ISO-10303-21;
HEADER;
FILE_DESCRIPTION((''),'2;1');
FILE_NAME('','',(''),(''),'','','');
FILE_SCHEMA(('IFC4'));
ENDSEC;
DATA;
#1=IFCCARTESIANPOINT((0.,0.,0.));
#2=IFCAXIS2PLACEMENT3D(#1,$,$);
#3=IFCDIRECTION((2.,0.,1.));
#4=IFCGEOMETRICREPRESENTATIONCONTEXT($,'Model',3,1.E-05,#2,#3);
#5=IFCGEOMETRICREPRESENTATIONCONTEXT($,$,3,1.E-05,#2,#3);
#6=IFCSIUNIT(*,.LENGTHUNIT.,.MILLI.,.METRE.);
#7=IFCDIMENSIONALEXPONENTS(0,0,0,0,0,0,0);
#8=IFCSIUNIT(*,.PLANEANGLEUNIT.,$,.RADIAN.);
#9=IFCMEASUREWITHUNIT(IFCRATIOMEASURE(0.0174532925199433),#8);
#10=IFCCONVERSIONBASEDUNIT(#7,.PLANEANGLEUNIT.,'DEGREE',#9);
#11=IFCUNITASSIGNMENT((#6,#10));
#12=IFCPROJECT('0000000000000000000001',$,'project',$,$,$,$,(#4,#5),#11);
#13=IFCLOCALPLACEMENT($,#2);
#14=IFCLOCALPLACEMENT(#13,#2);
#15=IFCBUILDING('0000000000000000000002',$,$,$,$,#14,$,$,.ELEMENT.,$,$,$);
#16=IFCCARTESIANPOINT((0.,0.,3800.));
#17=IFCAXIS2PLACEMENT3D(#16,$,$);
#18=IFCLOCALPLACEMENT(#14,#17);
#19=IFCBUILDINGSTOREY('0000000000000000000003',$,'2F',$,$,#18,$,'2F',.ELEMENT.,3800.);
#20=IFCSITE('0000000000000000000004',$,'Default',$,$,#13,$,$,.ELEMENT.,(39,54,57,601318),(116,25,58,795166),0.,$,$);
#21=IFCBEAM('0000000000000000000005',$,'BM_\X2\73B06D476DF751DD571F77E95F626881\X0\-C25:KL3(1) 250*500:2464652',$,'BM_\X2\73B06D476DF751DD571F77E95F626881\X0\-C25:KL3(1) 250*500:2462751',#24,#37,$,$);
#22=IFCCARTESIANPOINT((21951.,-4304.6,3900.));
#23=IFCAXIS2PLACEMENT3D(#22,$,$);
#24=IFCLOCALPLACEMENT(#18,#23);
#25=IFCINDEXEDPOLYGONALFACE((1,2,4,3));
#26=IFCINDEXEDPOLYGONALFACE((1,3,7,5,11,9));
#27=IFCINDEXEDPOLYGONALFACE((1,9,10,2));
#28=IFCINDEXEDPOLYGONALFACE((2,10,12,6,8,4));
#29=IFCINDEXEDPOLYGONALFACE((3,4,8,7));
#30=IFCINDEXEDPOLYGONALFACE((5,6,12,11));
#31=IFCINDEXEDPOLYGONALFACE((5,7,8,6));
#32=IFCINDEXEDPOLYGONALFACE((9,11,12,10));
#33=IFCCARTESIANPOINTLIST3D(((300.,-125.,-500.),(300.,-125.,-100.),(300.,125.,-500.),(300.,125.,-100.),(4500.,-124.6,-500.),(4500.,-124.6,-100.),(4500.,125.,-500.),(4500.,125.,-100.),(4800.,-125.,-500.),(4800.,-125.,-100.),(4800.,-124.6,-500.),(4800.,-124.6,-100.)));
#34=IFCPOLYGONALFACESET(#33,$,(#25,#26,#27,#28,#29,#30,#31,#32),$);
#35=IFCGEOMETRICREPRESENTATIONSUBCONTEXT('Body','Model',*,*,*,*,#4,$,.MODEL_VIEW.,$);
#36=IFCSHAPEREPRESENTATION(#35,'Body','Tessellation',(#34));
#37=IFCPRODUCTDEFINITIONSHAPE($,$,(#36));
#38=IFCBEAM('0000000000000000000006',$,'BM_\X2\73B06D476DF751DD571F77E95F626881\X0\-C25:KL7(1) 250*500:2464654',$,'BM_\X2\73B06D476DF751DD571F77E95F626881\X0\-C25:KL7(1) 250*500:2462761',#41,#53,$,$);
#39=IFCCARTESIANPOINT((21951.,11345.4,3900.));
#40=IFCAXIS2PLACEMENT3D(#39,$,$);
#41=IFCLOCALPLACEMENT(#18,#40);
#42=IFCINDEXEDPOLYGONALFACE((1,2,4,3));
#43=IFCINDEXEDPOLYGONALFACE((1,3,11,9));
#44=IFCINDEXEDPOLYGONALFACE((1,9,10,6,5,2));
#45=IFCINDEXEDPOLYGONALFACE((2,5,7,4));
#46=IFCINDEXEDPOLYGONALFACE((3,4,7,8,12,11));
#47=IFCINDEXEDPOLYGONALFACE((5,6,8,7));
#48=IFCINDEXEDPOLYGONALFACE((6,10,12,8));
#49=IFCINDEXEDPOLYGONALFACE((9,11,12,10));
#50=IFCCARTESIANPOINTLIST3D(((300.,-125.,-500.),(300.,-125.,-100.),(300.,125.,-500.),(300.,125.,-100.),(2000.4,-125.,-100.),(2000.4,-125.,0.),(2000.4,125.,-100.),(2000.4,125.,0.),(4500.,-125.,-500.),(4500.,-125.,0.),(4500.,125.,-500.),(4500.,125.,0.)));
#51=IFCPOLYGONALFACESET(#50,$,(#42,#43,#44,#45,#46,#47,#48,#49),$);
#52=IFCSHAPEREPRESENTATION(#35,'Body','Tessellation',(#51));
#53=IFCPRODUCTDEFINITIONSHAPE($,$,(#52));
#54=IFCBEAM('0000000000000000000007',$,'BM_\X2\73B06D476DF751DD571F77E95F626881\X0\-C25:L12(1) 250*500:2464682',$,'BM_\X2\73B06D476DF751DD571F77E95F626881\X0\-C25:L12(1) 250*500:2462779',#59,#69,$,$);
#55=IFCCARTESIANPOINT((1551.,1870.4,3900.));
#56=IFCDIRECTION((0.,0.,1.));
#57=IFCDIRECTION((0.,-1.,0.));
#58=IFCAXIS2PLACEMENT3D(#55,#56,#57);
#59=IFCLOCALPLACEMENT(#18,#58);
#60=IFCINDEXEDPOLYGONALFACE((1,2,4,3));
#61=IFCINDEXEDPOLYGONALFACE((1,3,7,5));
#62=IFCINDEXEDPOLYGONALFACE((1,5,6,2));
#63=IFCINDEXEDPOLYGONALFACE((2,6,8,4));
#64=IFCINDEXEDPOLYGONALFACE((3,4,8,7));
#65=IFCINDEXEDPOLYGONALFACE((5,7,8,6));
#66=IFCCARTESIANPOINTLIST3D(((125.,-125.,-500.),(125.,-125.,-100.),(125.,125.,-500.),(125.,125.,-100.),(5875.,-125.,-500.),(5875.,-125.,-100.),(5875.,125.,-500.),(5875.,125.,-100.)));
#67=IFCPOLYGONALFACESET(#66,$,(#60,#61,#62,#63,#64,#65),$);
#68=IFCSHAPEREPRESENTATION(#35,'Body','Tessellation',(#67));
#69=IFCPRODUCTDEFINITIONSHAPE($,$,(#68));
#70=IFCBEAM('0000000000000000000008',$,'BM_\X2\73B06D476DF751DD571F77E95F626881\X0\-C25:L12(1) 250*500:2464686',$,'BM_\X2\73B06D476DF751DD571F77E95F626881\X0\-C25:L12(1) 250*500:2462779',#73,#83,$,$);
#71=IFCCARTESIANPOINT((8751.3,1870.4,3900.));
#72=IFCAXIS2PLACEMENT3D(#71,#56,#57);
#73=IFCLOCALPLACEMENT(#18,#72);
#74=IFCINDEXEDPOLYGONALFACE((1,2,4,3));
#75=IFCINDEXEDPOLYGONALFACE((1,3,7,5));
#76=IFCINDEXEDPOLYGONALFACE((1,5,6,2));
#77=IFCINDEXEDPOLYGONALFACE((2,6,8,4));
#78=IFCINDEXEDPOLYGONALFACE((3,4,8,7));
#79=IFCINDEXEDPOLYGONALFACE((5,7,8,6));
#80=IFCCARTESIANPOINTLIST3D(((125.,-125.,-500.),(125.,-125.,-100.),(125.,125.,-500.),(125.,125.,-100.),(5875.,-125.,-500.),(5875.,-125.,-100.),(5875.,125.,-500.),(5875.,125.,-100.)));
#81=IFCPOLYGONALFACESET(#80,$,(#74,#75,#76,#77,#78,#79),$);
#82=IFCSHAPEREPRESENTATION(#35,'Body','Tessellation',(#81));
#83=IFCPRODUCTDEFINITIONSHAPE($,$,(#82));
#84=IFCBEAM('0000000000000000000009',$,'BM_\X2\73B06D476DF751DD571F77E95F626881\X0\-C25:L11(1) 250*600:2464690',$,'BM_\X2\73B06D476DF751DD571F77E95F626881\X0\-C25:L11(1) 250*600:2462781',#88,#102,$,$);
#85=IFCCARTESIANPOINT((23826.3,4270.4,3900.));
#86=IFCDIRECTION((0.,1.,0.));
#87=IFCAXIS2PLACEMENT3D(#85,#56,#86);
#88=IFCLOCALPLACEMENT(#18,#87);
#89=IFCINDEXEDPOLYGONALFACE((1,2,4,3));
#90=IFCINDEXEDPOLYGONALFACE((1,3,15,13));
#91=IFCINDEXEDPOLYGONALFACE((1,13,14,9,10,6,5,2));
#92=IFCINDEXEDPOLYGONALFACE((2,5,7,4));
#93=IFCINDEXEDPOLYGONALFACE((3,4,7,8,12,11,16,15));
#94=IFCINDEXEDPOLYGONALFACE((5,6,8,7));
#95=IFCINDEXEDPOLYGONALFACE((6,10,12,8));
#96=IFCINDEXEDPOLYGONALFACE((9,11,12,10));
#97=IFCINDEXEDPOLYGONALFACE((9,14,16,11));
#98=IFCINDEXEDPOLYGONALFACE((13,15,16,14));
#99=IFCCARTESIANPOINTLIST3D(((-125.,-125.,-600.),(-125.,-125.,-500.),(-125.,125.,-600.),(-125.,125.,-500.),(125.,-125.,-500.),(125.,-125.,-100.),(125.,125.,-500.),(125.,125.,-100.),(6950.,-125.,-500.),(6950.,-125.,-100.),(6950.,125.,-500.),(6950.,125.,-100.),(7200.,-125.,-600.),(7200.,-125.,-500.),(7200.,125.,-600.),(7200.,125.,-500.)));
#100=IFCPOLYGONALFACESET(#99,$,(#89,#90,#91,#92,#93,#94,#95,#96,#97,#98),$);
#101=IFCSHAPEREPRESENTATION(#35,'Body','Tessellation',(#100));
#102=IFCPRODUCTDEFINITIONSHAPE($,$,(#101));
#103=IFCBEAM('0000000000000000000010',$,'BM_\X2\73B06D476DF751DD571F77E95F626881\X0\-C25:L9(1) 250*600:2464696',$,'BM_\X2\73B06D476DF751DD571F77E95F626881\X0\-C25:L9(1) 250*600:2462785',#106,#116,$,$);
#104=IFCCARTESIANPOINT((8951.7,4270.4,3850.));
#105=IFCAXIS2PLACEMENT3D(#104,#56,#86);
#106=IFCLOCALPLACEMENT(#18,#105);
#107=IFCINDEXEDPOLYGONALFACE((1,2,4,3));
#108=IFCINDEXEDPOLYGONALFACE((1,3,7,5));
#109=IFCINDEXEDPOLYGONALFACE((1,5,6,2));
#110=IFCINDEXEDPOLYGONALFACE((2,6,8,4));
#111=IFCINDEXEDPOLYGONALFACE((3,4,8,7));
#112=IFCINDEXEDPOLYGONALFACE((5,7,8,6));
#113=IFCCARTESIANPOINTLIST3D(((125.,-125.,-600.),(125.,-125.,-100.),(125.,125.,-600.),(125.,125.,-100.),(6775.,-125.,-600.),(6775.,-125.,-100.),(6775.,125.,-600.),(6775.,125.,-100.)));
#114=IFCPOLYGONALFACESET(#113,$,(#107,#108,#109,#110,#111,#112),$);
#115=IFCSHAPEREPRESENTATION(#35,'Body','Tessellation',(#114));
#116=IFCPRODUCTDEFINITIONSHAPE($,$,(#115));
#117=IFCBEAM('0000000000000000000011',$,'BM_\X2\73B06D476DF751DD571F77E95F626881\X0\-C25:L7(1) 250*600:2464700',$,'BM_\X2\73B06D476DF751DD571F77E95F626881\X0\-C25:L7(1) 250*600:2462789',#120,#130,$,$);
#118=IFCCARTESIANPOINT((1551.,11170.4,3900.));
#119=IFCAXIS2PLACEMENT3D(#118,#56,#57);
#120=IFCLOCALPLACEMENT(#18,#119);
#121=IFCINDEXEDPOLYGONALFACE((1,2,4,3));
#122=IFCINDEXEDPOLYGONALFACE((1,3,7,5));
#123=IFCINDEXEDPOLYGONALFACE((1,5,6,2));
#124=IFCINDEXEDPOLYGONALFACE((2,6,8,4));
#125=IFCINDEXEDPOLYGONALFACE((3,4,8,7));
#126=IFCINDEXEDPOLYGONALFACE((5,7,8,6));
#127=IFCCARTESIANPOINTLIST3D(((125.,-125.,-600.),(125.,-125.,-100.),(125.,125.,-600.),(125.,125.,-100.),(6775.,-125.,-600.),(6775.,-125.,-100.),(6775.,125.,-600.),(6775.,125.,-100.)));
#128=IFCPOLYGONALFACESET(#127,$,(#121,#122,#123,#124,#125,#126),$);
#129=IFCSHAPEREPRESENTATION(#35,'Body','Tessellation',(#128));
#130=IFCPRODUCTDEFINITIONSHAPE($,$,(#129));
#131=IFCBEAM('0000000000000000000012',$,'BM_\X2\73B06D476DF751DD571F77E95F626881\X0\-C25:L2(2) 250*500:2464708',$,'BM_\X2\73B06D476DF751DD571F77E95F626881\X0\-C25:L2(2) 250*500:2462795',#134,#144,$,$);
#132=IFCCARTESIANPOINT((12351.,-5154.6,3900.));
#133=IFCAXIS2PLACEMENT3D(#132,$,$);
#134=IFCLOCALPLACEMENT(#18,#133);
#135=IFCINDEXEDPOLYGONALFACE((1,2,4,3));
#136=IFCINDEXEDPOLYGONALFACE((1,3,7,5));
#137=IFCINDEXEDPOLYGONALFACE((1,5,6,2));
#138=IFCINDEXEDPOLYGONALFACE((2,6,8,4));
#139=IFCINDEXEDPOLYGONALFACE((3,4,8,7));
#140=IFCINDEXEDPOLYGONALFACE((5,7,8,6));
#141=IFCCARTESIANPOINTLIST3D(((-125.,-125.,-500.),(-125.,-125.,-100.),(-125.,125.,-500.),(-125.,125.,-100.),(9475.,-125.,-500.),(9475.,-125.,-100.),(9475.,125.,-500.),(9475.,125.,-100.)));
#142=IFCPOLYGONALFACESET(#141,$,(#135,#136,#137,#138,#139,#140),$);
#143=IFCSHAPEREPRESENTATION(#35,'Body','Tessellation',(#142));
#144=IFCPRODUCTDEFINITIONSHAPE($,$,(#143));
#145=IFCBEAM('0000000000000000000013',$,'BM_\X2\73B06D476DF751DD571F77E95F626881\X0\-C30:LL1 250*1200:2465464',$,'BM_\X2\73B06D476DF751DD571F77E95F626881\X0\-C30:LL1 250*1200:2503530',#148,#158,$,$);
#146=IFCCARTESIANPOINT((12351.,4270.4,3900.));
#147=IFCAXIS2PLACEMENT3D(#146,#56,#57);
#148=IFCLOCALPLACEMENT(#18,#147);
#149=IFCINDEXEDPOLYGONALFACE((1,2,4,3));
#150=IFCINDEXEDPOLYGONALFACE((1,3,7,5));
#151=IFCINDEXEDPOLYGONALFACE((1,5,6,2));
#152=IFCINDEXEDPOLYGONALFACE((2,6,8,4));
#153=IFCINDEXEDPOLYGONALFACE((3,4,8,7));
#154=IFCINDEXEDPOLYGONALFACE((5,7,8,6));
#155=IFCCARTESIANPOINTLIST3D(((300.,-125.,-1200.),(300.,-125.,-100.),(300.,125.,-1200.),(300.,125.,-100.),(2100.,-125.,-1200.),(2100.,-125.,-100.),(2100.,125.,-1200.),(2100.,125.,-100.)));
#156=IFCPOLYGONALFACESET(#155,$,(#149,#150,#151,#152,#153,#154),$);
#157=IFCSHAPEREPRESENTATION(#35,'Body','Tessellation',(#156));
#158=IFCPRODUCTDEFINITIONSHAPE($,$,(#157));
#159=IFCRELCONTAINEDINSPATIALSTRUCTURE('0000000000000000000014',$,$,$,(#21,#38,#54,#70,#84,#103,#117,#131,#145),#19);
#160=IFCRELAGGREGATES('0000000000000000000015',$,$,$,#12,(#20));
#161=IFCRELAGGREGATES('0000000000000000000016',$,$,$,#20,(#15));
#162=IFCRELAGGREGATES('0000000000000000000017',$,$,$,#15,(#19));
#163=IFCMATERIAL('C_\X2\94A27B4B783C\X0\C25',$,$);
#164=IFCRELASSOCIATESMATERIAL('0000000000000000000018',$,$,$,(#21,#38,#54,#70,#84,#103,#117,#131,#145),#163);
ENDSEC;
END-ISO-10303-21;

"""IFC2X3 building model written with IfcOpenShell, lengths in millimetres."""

from ifc_helpers import new_model, entity, si_unit, converted_unit, direction, frame, frame_2d, origin, place, context, subcontext, project, spatial, polyline, rectangle, extrude, clip, bounded_halfspace, material, element, save


model = new_model("IFC2X3")

# Units and contexts
model_context = context("Model", 3, precision=1e-05, world=origin(), true_north=direction((2.0, 0.0, 1.0)))
context_of_model = context(None, 3, precision=1e-05, world=origin(), true_north=direction((2.0, 0.0, 1.0)))
body_context = subcontext(model_context, "Body", "Model", "MODEL_VIEW")
ifc_project = project(units=[si_unit("LENGTHUNIT", "METRE", prefix="MILLI"), converted_unit("PLANEANGLEUNIT", "DEGREE", entity("IfcRatioMeasure", 0.0174532925199433), si_unit("PLANEANGLEUNIT", "RADIAN"), dimensions=[0, 0, 0, 0, 0, 0, 0])], contexts=[model_context, context_of_model])

# Site, building, storey
site_placement = place(None, origin())
site = spatial("IfcSite", under=ifc_project, at=site_placement, Name="Default", CompositionType="ELEMENT", RefLatitude=(39, 54, 57, 601318), RefLongitude=(116, 25, 58, 795166), RefElevation=0.0)
building_placement = place(site_placement, origin())
building = spatial("IfcBuilding", under=site, at=building_placement, CompositionType="ELEMENT")
storey_placement = place(building_placement, frame((0.0, 0.0, 3800.0)))
storey = spatial("IfcBuildingStorey", under=building, at=storey_placement, Name="2F", LongName="2F", CompositionType="ELEMENT", Elevation=3800.0)

# Beams
ifc_material_1 = material(Name="C_钢筋砼C25")
beam_1_placement = place(storey_placement, frame((21951.0, -4304.6, 3900.0)))
element("IfcBeam", 1, at=beam_1_placement, inside=storey, material=ifc_material_1, Name="BM_现浇混凝土矩形梁-C25:KL3(1) 250*500:2464652", ObjectType="BM_现浇混凝土矩形梁-C25:KL3(1) 250*500:2462751", context=body_context, shape_type="Clipping", body=[
    clip(extrude(rectangle(XDim=400.0, YDim=250.0, at=frame_2d((0.0, 0.0), x_axis=(1.0, 0.0))), frame((300.0, 0.0, -300.0), z_axis=(1.0, 0.0, 0.0), x_axis=(0.0, 0.0, -1.0)), (0.0, 0.0, 1.0), 4500.0), bounded_halfspace(frame((4500.0, 475.4, 0.0), z_axis=(1.0, 0.0, 0.0), x_axis=(0.0, 1.0, 0.0)), False, frame((300.0, 0.0, -300.0), z_axis=(1.0, 0.0, 0.0), x_axis=(0.0, 0.0, -1.0)), polyline([(200.0, -124.6), (200.0, 125.0), (-200.0, 125.0), (-200.0, -124.6), (200.0, -124.6)]))),
])
beam_2_placement = place(storey_placement, frame((21951.0, 11345.4, 3900.0)))
element("IfcBeam", 2, at=beam_2_placement, inside=storey, material=ifc_material_1, Name="BM_现浇混凝土矩形梁-C25:KL7(1) 250*500:2464654", ObjectType="BM_现浇混凝土矩形梁-C25:KL7(1) 250*500:2462761", context=body_context, shape_type="Clipping", body=[
    clip(extrude(rectangle(XDim=500.0, YDim=250.0, at=frame_2d((0.0, 0.0), x_axis=(0.0, 1.0))), frame((300.0, 0.0, -250.0), z_axis=(1.0, 0.0, 0.0), x_axis=(0.0, 1.0, 0.0)), (0.0, 0.0, 1.0), 4200.0), bounded_halfspace(frame((2000.4, 125.0, -100.0), z_axis=(-1.0, 0.0, 0.0), x_axis=(0.0, -1.0, 0.0)), False, frame((300.0, 0.0, -250.0), z_axis=(1.0, 0.0, 0.0), x_axis=(0.0, 1.0, 0.0)), polyline([(125.0, 150.0), (-125.0, 150.0), (-125.0, 250.0), (125.0, 250.0), (125.0, 150.0)]))),
])
beam_3_placement = place(storey_placement, frame((1551.0, 1870.4, 3900.0), z_axis=(0.0, 0.0, 1.0), x_axis=(0.0, -1.0, 0.0)))
element("IfcBeam", 3, at=beam_3_placement, inside=storey, material=ifc_material_1, Name="BM_现浇混凝土矩形梁-C25:L12(1) 250*500:2464682", ObjectType="BM_现浇混凝土矩形梁-C25:L12(1) 250*500:2462779", context=body_context, shape_type="SweptSolid", body=[
    extrude(rectangle(XDim=400.0, YDim=250.0, at=frame_2d((0.0, 0.0), x_axis=(1.0, 0.0))), frame((125.0, 0.0, -300.0), z_axis=(1.0, 0.0, 0.0), x_axis=(0.0, 0.0, -1.0)), (0.0, 0.0, 1.0), 5750.0),
])
beam_4_placement = place(storey_placement, frame((8751.3, 1870.4, 3900.0), z_axis=(0.0, 0.0, 1.0), x_axis=(0.0, -1.0, 0.0)))
element("IfcBeam", 4, at=beam_4_placement, inside=storey, material=ifc_material_1, Name="BM_现浇混凝土矩形梁-C25:L12(1) 250*500:2464686", ObjectType="BM_现浇混凝土矩形梁-C25:L12(1) 250*500:2462779", context=body_context, shape_type="SweptSolid", body=[
    extrude(rectangle(XDim=400.0, YDim=250.0, at=frame_2d((0.0, 0.0), x_axis=(1.0, 0.0))), frame((125.0, 0.0, -300.0), z_axis=(1.0, 0.0, 0.0), x_axis=(0.0, 0.0, -1.0)), (0.0, 0.0, 1.0), 5750.0),
])
beam_5_placement = place(storey_placement, frame((23826.3, 4270.4, 3900.0), z_axis=(0.0, 0.0, 1.0), x_axis=(0.0, 1.0, 0.0)))
element("IfcBeam", 5, at=beam_5_placement, inside=storey, material=ifc_material_1, Name="BM_现浇混凝土矩形梁-C25:L11(1) 250*600:2464690", ObjectType="BM_现浇混凝土矩形梁-C25:L11(1) 250*600:2462781", context=body_context, shape_type="Clipping", body=[
    clip(clip(extrude(rectangle(XDim=500.0, YDim=250.0, at=frame_2d((0.0, 0.0), x_axis=(0.0, 1.0))), frame((-125.0, 0.0, -350.0), z_axis=(1.0, 0.0, 0.0), x_axis=(0.0, 1.0, 0.0)), (0.0, 0.0, 1.0), 7325.0), bounded_halfspace(frame((125.0, 11162.7, 0.0), z_axis=(-1.0, 0.0, 0.0), x_axis=(0.0, 0.0, -1.0)), False, frame((-125.0, 0.0, -350.0), z_axis=(1.0, 0.0, 0.0), x_axis=(0.0, 1.0, 0.0)), polyline([(125.0, -150.0), (-125.0, -150.0), (-125.0, 250.0), (125.0, 250.0), (125.0, -150.0)]))), bounded_halfspace(frame((6950.0, 1562.7, -500.0), z_axis=(1.0, 0.0, 0.0), x_axis=(0.0, 0.0, 1.0)), False, frame((-125.0, 0.0, -350.0), z_axis=(1.0, 0.0, 0.0), x_axis=(0.0, 1.0, 0.0)), polyline([(-125.0, -150.0), (125.0, -150.0), (125.0, 250.0), (-125.0, 250.0), (-125.0, -150.0)]))),
])
beam_6_placement = place(storey_placement, frame((8951.7, 4270.4, 3850.0), z_axis=(0.0, 0.0, 1.0), x_axis=(0.0, 1.0, 0.0)))
element("IfcBeam", 6, at=beam_6_placement, inside=storey, material=ifc_material_1, Name="BM_现浇混凝土矩形梁-C25:L9(1) 250*600:2464696", ObjectType="BM_现浇混凝土矩形梁-C25:L9(1) 250*600:2462785", context=body_context, shape_type="SweptSolid", body=[
    extrude(rectangle(XDim=500.0, YDim=250.0, at=frame_2d((0.0, 0.0), x_axis=(1.0, 0.0))), frame((125.0, 0.0, -350.0), z_axis=(1.0, 0.0, 0.0), x_axis=(0.0, 0.0, -1.0)), (0.0, 0.0, 1.0), 6650.0),
])
beam_7_placement = place(storey_placement, frame((1551.0, 11170.4, 3900.0), z_axis=(0.0, 0.0, 1.0), x_axis=(0.0, -1.0, 0.0)))
element("IfcBeam", 7, at=beam_7_placement, inside=storey, material=ifc_material_1, Name="BM_现浇混凝土矩形梁-C25:L7(1) 250*600:2464700", ObjectType="BM_现浇混凝土矩形梁-C25:L7(1) 250*600:2462789", context=body_context, shape_type="SweptSolid", body=[
    extrude(rectangle(XDim=500.0, YDim=250.0, at=frame_2d((0.0, 0.0), x_axis=(1.0, 0.0))), frame((125.0, 0.0, -350.0), z_axis=(1.0, 0.0, 0.0), x_axis=(0.0, 0.0, -1.0)), (0.0, 0.0, 1.0), 6650.0),
])
beam_8_placement = place(storey_placement, frame((12351.0, -5154.6, 3900.0)))
element("IfcBeam", 8, at=beam_8_placement, inside=storey, material=ifc_material_1, Name="BM_现浇混凝土矩形梁-C25:L2(2) 250*500:2464708", ObjectType="BM_现浇混凝土矩形梁-C25:L2(2) 250*500:2462795", context=body_context, shape_type="SweptSolid", body=[
    extrude(rectangle(XDim=400.0, YDim=250.0, at=frame_2d((0.0, 0.0), x_axis=(1.0, 0.0))), frame((-125.0, 0.0, -300.0), z_axis=(1.0, 0.0, 0.0), x_axis=(0.0, 0.0, -1.0)), (0.0, 0.0, 1.0), 9600.0),
])
beam_9_placement = place(storey_placement, frame((12351.0, 4270.4, 3900.0), z_axis=(0.0, 0.0, 1.0), x_axis=(0.0, -1.0, 0.0)))
element("IfcBeam", 9, at=beam_9_placement, inside=storey, material=ifc_material_1, Name="BM_现浇混凝土矩形梁-C30:LL1 250*1200:2465464", ObjectType="BM_现浇混凝土矩形梁-C30:LL1 250*1200:2503530", context=body_context, shape_type="SweptSolid", body=[
    extrude(rectangle(XDim=1100.0, YDim=250.0, at=frame_2d((0.0, 0.0), x_axis=(1.0, 0.0))), frame((300.0, 0.0, -650.0), z_axis=(1.0, 0.0, 0.0), x_axis=(0.0, 0.0, -1.0)), (0.0, 0.0, 1.0), 1800.0),
])

save(model, "model.ifc")
